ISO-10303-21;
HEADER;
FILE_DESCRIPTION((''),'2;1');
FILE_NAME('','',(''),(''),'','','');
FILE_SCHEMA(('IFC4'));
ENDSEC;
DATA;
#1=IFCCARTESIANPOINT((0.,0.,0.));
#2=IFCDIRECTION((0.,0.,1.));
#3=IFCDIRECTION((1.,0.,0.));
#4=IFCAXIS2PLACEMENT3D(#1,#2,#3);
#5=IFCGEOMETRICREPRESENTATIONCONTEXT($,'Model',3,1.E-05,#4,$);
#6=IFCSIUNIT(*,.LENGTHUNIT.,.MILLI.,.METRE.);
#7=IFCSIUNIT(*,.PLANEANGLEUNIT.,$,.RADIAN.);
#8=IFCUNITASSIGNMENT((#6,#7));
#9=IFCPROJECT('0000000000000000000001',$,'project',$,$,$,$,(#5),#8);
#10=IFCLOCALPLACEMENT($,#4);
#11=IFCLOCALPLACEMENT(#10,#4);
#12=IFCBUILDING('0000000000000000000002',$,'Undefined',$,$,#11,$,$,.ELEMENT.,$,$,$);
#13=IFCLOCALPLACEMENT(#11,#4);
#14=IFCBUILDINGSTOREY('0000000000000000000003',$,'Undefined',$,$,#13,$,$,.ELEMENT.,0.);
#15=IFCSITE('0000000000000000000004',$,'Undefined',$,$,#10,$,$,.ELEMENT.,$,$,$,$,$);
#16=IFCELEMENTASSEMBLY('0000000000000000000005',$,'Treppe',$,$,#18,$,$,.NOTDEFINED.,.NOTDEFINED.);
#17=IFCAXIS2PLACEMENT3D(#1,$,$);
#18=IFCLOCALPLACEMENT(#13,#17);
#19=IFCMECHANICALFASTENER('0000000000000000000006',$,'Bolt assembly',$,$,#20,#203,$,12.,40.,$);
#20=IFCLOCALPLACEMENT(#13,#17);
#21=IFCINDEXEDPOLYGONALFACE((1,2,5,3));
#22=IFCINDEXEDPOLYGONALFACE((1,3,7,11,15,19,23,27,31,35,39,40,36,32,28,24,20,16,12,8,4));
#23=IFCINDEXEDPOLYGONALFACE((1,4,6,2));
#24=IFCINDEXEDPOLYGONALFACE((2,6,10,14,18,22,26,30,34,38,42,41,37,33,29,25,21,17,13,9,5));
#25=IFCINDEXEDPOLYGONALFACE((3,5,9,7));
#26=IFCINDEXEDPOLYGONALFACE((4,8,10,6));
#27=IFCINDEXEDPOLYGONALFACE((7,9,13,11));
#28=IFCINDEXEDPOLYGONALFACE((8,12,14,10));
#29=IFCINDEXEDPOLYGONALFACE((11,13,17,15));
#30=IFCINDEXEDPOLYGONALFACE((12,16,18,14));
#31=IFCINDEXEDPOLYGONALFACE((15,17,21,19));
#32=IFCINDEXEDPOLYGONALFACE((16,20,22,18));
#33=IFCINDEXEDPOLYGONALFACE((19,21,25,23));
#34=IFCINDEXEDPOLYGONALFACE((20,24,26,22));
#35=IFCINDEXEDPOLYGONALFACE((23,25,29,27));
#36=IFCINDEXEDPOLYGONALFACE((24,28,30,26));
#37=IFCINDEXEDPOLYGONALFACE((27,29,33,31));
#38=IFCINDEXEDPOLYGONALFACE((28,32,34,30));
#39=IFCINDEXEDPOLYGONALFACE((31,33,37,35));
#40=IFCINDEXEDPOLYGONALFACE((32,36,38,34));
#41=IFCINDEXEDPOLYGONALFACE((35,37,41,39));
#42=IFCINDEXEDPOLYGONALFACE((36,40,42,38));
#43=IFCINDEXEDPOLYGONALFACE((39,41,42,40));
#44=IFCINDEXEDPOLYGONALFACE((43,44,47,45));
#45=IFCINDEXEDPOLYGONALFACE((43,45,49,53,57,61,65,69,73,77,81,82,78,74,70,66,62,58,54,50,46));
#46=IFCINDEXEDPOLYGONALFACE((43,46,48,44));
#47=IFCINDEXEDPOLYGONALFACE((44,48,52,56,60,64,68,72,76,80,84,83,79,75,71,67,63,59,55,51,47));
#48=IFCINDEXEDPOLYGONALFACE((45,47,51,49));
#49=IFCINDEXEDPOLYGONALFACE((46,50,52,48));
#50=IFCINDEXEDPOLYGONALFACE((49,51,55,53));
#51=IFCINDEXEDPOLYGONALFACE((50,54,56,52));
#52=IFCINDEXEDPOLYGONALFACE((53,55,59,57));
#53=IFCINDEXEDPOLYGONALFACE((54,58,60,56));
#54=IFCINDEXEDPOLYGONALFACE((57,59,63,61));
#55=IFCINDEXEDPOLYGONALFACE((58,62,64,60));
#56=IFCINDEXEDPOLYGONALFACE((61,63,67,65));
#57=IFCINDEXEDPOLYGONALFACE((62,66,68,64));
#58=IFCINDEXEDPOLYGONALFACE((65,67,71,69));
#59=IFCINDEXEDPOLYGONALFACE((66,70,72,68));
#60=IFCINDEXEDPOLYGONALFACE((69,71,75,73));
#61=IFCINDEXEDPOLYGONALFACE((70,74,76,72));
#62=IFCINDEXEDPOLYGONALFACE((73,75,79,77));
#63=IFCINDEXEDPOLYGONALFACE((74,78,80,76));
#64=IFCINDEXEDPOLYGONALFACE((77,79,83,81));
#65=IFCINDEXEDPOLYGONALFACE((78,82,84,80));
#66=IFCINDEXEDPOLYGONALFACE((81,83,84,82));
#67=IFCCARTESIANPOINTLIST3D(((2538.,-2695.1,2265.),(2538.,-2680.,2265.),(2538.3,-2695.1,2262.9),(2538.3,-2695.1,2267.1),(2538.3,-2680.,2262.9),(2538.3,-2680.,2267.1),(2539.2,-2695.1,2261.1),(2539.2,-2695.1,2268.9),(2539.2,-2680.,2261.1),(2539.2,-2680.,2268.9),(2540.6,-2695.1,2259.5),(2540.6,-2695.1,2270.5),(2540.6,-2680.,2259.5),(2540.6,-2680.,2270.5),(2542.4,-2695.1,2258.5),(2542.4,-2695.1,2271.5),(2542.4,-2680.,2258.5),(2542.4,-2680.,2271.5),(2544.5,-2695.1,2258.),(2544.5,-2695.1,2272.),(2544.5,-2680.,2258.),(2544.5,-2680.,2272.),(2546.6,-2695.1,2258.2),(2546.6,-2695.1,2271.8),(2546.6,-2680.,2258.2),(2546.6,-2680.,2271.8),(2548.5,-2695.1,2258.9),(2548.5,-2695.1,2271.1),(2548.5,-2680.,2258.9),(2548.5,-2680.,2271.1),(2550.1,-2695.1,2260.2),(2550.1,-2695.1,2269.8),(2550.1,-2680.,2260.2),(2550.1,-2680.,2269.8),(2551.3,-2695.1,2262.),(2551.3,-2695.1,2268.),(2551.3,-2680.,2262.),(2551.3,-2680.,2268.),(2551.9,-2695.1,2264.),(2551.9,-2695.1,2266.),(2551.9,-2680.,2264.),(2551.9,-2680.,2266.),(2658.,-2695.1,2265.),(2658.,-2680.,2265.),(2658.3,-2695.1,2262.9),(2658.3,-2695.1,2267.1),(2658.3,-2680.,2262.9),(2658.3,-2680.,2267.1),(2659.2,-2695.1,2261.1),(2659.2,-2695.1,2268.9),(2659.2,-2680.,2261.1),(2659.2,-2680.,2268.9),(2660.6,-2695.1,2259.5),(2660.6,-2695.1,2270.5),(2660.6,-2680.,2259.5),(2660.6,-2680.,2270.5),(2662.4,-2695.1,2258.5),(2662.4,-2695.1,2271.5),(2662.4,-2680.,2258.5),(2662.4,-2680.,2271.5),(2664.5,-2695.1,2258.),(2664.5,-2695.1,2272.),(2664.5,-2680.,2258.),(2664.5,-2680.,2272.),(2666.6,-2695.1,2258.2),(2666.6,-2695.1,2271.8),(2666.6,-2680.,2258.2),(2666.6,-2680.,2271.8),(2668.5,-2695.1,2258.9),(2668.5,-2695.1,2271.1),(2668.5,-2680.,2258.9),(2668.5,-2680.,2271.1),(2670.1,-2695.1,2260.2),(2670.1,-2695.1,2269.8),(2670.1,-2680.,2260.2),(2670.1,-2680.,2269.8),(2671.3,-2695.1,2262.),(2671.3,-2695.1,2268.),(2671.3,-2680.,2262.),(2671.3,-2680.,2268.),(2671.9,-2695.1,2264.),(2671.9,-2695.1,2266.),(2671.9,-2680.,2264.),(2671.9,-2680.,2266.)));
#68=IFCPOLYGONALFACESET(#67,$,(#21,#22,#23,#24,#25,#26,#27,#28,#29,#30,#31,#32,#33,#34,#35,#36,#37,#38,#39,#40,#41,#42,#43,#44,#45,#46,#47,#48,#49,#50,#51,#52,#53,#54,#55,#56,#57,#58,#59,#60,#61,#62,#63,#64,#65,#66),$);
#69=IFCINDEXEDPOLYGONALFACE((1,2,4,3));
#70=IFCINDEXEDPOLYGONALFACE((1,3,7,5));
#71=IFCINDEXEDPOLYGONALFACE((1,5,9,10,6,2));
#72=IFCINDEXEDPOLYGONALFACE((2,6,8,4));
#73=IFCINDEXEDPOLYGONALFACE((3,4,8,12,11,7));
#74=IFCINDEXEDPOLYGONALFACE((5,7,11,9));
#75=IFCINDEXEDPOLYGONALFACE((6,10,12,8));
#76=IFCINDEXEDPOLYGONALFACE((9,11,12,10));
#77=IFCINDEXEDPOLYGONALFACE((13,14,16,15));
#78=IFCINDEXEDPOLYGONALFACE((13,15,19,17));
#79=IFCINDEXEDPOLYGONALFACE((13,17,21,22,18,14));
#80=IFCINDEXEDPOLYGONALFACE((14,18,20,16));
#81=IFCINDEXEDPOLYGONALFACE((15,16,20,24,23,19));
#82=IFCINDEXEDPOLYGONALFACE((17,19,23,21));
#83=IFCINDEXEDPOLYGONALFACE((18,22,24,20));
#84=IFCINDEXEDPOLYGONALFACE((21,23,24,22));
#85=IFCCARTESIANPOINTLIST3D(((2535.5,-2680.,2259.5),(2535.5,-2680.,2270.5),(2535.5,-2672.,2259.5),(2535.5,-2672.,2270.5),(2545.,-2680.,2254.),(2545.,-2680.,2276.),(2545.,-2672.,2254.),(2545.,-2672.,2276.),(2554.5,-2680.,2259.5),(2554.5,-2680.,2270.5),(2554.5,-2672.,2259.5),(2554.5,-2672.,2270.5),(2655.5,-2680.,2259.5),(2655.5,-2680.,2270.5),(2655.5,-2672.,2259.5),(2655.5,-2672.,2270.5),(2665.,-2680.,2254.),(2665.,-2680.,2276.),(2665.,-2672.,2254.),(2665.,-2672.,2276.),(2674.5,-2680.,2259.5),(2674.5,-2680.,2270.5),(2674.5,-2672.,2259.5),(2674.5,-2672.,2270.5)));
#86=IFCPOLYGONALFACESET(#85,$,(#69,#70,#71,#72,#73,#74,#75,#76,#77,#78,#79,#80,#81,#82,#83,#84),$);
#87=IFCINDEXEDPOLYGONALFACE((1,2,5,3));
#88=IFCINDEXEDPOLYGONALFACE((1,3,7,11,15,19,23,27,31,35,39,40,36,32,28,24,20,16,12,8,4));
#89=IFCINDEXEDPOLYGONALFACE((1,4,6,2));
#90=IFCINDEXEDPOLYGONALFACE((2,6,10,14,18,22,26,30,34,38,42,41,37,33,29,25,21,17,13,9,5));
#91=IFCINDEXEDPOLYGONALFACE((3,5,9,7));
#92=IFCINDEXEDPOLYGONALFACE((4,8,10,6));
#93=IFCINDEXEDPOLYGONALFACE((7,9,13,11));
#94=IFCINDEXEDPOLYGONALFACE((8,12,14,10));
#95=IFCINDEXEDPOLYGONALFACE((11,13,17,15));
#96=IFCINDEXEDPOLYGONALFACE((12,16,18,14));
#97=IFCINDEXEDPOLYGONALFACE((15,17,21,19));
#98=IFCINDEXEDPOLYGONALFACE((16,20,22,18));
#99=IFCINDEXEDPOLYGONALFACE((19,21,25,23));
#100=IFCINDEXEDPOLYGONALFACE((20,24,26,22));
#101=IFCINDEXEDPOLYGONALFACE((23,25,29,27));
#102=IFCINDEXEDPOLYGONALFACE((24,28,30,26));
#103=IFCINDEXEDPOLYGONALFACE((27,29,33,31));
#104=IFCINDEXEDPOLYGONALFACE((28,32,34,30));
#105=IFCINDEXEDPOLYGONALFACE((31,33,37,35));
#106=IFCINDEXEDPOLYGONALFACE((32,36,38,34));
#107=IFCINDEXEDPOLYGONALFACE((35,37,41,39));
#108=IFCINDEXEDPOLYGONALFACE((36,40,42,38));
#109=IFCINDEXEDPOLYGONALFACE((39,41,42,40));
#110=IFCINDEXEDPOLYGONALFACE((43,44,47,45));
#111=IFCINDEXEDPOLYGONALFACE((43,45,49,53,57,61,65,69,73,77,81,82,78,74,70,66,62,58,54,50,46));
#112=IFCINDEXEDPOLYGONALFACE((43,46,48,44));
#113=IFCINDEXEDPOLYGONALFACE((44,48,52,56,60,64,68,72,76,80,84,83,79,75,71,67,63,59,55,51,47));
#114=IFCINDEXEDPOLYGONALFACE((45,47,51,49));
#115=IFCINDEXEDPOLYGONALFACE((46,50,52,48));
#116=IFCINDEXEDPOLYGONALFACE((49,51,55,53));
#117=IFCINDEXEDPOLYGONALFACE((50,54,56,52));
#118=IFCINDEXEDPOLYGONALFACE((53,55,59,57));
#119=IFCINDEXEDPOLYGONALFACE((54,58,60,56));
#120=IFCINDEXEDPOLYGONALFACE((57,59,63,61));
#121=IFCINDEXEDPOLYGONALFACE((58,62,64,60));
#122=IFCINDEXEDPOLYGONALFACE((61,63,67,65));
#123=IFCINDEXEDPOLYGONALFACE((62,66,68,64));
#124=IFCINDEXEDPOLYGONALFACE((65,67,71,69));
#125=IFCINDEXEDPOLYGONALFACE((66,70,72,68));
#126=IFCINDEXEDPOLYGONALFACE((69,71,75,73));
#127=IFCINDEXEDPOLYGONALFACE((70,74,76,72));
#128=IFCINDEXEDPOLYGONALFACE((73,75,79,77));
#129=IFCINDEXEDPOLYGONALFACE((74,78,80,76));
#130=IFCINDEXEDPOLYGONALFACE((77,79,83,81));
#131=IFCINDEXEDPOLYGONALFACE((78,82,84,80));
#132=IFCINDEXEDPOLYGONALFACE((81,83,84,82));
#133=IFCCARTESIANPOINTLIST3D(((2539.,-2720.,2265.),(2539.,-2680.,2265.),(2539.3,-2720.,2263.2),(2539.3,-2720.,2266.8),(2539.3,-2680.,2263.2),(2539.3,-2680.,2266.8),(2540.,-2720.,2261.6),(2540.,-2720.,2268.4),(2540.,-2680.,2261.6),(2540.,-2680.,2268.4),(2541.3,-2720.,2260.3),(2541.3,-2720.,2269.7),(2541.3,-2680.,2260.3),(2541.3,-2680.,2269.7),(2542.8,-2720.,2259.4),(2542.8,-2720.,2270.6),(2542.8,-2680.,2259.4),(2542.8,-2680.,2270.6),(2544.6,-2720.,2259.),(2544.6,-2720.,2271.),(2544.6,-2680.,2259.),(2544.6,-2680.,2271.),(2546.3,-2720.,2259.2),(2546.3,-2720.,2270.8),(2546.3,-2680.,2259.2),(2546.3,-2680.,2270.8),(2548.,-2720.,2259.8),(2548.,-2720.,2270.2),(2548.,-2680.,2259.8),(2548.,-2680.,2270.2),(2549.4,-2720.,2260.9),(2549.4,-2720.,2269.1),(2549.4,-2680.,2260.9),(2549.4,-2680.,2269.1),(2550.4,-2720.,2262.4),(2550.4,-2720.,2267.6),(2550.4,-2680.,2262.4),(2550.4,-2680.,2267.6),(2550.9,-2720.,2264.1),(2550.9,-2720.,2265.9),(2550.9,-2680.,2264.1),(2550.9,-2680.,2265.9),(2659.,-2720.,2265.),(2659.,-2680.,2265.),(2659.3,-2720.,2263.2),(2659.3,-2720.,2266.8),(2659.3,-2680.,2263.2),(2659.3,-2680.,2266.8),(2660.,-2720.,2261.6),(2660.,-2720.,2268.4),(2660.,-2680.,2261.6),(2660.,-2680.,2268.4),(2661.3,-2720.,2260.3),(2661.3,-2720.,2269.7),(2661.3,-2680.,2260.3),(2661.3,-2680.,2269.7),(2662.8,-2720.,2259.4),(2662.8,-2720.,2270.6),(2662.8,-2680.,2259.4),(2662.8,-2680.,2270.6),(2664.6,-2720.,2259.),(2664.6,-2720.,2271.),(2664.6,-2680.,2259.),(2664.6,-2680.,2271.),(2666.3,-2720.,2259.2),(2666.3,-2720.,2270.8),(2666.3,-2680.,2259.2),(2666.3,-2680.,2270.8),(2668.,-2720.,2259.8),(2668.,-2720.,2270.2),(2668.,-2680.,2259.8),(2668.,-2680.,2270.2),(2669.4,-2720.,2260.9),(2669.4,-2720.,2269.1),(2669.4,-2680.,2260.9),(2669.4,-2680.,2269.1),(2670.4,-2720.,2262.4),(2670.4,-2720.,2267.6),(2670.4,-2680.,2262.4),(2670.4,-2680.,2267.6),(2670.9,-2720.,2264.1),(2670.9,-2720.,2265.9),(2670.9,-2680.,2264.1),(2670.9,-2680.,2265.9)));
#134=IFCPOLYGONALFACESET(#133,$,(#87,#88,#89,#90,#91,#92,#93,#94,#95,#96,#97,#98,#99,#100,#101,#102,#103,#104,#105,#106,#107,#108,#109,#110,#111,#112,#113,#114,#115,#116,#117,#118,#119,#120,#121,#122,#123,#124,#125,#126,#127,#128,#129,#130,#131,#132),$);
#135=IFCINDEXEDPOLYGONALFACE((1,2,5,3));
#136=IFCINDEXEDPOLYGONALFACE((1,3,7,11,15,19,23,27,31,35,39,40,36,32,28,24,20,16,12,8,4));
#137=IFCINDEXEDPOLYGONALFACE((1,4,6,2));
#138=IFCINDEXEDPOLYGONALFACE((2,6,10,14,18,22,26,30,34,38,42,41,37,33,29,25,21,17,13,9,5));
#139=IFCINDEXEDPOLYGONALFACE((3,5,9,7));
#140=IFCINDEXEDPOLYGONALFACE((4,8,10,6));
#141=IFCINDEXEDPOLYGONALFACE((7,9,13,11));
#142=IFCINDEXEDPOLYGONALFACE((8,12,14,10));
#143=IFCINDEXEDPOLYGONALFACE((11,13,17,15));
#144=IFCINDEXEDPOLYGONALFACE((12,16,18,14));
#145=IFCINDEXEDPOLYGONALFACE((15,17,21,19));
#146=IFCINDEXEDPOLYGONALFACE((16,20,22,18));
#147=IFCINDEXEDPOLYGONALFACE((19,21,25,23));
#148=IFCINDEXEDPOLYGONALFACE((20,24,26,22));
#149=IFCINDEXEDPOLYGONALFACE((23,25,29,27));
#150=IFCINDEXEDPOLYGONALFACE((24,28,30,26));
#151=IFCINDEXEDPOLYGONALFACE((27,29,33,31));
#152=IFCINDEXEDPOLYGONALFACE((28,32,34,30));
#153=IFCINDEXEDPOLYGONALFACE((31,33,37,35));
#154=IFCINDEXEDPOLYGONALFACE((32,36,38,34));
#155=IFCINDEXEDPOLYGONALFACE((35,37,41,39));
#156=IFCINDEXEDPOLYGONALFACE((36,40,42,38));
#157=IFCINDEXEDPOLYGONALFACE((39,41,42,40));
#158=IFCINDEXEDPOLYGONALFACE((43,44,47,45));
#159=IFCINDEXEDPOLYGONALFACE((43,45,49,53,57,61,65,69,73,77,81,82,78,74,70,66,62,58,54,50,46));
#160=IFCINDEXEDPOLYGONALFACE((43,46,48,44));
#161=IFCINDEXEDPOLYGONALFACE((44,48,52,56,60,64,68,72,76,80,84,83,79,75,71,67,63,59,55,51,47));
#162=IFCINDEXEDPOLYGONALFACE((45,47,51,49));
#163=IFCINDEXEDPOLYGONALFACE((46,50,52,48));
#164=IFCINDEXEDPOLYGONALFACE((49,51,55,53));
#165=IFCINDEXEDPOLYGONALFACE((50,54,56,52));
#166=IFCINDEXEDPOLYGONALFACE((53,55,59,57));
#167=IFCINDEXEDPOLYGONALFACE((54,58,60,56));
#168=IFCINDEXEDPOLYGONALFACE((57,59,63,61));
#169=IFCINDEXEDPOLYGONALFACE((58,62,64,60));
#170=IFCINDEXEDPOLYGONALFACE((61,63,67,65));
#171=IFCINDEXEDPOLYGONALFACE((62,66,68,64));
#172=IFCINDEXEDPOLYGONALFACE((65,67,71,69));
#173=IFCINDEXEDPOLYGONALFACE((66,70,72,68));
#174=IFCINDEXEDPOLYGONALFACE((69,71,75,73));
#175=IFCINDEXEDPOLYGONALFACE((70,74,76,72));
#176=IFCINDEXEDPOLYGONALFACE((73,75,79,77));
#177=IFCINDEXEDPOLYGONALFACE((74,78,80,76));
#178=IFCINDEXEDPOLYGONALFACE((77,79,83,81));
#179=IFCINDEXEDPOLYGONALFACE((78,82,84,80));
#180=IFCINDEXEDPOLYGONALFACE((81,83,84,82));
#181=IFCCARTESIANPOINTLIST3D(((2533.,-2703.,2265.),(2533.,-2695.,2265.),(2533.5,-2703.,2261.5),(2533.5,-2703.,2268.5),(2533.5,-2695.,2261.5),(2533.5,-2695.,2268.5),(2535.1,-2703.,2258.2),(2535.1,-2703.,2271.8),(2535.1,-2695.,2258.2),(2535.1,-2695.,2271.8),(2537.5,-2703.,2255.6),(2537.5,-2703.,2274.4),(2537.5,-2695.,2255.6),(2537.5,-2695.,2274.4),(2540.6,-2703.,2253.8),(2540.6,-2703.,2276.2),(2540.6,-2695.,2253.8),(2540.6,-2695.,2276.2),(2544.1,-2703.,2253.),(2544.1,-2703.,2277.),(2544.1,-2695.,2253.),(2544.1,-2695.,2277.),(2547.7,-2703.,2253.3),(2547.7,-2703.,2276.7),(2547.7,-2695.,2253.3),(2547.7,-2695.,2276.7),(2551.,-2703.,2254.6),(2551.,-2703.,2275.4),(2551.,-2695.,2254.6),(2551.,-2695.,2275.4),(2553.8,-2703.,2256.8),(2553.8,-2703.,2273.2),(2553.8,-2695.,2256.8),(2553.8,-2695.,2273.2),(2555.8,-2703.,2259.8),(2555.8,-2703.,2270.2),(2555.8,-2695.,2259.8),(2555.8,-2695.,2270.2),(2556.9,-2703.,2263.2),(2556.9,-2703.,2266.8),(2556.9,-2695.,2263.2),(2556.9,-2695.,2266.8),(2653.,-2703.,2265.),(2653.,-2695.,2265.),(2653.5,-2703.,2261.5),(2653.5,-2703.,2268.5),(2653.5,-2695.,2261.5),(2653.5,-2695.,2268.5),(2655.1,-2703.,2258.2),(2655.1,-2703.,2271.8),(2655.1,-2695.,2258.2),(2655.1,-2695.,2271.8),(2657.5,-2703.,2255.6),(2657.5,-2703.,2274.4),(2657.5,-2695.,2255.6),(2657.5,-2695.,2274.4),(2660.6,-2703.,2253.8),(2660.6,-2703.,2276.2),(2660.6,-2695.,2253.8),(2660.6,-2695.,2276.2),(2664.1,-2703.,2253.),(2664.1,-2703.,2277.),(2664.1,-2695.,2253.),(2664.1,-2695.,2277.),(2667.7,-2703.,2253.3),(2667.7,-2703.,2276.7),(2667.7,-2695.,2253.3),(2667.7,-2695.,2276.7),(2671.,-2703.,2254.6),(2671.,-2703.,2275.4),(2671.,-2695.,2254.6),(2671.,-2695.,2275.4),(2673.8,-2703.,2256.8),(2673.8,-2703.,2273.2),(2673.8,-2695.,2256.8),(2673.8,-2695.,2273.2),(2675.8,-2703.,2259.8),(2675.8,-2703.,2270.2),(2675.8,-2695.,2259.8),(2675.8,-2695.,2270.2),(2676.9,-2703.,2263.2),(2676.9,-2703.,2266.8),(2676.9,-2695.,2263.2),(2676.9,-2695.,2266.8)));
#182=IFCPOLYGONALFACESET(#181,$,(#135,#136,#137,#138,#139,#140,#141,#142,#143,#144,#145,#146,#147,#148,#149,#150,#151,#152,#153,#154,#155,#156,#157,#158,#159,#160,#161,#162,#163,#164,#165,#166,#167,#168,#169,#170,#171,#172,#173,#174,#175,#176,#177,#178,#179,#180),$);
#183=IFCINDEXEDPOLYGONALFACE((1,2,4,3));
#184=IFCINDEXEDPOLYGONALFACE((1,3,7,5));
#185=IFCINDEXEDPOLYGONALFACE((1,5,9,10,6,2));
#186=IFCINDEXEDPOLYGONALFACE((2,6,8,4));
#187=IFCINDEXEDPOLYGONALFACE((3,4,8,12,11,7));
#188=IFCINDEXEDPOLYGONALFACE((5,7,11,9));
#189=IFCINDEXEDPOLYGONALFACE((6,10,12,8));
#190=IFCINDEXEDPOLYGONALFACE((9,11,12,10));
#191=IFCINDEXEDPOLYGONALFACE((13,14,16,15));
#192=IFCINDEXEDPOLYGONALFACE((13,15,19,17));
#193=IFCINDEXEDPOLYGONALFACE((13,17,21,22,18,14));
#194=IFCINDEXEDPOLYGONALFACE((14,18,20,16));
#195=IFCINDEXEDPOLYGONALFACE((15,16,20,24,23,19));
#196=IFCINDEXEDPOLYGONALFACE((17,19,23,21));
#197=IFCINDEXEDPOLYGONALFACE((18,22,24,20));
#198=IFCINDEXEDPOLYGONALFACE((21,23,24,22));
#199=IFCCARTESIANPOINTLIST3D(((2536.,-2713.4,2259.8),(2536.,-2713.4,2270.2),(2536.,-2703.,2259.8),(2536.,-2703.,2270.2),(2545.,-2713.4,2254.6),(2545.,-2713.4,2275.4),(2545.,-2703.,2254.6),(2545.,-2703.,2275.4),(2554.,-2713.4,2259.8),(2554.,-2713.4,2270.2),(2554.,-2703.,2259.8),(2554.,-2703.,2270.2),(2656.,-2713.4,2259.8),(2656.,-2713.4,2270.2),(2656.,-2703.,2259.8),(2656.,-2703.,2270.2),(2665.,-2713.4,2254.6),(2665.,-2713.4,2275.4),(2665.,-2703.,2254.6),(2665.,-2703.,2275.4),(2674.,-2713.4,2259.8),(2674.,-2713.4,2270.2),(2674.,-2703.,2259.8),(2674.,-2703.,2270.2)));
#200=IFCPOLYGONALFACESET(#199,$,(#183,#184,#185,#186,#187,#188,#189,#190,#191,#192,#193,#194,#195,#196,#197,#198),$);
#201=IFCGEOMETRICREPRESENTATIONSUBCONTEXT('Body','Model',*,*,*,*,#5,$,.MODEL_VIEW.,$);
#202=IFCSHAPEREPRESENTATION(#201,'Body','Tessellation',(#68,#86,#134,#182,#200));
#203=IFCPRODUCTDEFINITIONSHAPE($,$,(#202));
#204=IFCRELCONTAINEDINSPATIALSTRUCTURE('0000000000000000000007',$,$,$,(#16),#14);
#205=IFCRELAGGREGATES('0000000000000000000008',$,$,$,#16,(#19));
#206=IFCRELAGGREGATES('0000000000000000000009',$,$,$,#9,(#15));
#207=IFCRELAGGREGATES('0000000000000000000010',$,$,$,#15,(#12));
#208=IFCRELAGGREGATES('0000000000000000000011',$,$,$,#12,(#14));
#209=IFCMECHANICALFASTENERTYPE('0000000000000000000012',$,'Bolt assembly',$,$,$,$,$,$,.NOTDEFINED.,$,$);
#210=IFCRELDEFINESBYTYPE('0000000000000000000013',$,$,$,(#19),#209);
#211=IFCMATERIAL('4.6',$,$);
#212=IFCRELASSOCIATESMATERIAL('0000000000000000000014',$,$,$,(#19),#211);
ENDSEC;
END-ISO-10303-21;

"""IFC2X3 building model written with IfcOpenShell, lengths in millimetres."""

from ifc_helpers import new_model, si_unit, frame, origin_with_axes, origin_2d_with_axis, place, context, subcontext, project, spatial, polyline, circle, outline, extrude, source, transform, mapped, material, type_object, element, aggregate, save


model = new_model("IFC2X3")

# Units and contexts
model_context = context("Model", 3, precision=1e-05, world=origin_with_axes())
body_context = subcontext(model_context, "Body", "Model", "MODEL_VIEW")
ifc_project = project(units=[si_unit("LENGTHUNIT", "METRE", prefix="MILLI"), si_unit("PLANEANGLEUNIT", "RADIAN")], contexts=[model_context])

# Site, building, storey
site_placement = place(None, origin_with_axes())
site = spatial("IfcSite", under=ifc_project, at=site_placement, Name="Undefined", CompositionType="ELEMENT")
building_placement = place(site_placement, origin_with_axes())
building = spatial("IfcBuilding", under=site, at=building_placement, Name="Undefined", CompositionType="ELEMENT")
storey_placement = place(building_placement, origin_with_axes())
storey = spatial("IfcBuildingStorey", under=building, at=storey_placement, Name="Undefined", CompositionType="ELEMENT", Elevation=0.0)

# Shared definitions
mechanical_fastener_type = type_object("IfcMechanicalFastenerType", Name="Bolt assembly")

# Shared definitions
ifc_material_1 = material(Name="4.6")

# Element assembly, mechanical fastener
assembly_1_placement = place(storey_placement, origin_with_axes())
assembly_1 = element("IfcElementAssembly", 1, at=assembly_1_placement, inside=storey, Name="Treppe", AssemblyPlace="NOTDEFINED", PredefinedType="NOTDEFINED")
shared_shape_1 = source(origin_with_axes(), body_context, "Body", "SweptSolid", [
    extrude(circle(Radius=7.0, at=origin_2d_with_axis()), frame((0.0, -15.0, 0.0), z_axis=(0.0, 1.0, 0.0), x_axis=(1.0, 0.0, 0.0)), (0.0, 0.0, 1.0), 15.1),
    extrude(outline(polyline([(9.5, -5.5), (9.5, 5.5), (0.0, 11.0), (-9.5, 5.5), (-9.5, -5.5), (0.0, -11.0), (9.5, -5.5)])), frame((0.0, -23.0, 0.0), z_axis=(0.0, 1.0, 0.0), x_axis=(1.0, 0.0, 0.0)), (0.0, 0.0, 1.0), 8.0),
    extrude(circle(Radius=6.0, at=origin_2d_with_axis()), frame((0.0, -15.0, 0.0), z_axis=(0.0, 1.0, 0.0), x_axis=(1.0, 0.0, 0.0)), (0.0, 0.0, 1.0), 40.0),
    extrude(circle(Radius=12.0, at=origin_2d_with_axis()), frame((0.0, 0.0, 0.0), z_axis=(0.0, 1.0, 0.0), x_axis=(1.0, 0.0, 0.0)), (0.0, 0.0, 1.0), 8.0),
    extrude(outline(polyline([(9.0, -5.2), (9.0, 5.2), (0.0, 10.4), (-9.0, 5.2), (-9.0, -5.2), (0.0, -10.4), (9.0, -5.2)])), frame((0.0, 8.0, 0.0), z_axis=(0.0, 1.0, 0.0), x_axis=(1.0, 0.0, 0.0)), (0.0, 0.0, 1.0), 10.4),
])
mechanical_fastener_1_placement = place(assembly_1_placement, frame((2665.0, -2695.0, 2265.0), z_axis=(0.0, 0.0, 1.0), x_axis=(-1.0, 0.0, 0.0)))
mechanical_fastener_1 = element("IfcMechanicalFastener", 2, at=mechanical_fastener_1_placement, type_object=mechanical_fastener_type, material=ifc_material_1, Name="Bolt assembly", NominalDiameter=12.0, NominalLength=40.0, context=body_context, shape_type="MappedRepresentation", body=[
    mapped(shared_shape_1, transform((0.0, 0.0, 0.0))),
    mapped(shared_shape_1, transform((120.0, 0.0, 0.0))),
])
aggregate(assembly_1, [mechanical_fastener_1])

save(model, "model.ifc")
